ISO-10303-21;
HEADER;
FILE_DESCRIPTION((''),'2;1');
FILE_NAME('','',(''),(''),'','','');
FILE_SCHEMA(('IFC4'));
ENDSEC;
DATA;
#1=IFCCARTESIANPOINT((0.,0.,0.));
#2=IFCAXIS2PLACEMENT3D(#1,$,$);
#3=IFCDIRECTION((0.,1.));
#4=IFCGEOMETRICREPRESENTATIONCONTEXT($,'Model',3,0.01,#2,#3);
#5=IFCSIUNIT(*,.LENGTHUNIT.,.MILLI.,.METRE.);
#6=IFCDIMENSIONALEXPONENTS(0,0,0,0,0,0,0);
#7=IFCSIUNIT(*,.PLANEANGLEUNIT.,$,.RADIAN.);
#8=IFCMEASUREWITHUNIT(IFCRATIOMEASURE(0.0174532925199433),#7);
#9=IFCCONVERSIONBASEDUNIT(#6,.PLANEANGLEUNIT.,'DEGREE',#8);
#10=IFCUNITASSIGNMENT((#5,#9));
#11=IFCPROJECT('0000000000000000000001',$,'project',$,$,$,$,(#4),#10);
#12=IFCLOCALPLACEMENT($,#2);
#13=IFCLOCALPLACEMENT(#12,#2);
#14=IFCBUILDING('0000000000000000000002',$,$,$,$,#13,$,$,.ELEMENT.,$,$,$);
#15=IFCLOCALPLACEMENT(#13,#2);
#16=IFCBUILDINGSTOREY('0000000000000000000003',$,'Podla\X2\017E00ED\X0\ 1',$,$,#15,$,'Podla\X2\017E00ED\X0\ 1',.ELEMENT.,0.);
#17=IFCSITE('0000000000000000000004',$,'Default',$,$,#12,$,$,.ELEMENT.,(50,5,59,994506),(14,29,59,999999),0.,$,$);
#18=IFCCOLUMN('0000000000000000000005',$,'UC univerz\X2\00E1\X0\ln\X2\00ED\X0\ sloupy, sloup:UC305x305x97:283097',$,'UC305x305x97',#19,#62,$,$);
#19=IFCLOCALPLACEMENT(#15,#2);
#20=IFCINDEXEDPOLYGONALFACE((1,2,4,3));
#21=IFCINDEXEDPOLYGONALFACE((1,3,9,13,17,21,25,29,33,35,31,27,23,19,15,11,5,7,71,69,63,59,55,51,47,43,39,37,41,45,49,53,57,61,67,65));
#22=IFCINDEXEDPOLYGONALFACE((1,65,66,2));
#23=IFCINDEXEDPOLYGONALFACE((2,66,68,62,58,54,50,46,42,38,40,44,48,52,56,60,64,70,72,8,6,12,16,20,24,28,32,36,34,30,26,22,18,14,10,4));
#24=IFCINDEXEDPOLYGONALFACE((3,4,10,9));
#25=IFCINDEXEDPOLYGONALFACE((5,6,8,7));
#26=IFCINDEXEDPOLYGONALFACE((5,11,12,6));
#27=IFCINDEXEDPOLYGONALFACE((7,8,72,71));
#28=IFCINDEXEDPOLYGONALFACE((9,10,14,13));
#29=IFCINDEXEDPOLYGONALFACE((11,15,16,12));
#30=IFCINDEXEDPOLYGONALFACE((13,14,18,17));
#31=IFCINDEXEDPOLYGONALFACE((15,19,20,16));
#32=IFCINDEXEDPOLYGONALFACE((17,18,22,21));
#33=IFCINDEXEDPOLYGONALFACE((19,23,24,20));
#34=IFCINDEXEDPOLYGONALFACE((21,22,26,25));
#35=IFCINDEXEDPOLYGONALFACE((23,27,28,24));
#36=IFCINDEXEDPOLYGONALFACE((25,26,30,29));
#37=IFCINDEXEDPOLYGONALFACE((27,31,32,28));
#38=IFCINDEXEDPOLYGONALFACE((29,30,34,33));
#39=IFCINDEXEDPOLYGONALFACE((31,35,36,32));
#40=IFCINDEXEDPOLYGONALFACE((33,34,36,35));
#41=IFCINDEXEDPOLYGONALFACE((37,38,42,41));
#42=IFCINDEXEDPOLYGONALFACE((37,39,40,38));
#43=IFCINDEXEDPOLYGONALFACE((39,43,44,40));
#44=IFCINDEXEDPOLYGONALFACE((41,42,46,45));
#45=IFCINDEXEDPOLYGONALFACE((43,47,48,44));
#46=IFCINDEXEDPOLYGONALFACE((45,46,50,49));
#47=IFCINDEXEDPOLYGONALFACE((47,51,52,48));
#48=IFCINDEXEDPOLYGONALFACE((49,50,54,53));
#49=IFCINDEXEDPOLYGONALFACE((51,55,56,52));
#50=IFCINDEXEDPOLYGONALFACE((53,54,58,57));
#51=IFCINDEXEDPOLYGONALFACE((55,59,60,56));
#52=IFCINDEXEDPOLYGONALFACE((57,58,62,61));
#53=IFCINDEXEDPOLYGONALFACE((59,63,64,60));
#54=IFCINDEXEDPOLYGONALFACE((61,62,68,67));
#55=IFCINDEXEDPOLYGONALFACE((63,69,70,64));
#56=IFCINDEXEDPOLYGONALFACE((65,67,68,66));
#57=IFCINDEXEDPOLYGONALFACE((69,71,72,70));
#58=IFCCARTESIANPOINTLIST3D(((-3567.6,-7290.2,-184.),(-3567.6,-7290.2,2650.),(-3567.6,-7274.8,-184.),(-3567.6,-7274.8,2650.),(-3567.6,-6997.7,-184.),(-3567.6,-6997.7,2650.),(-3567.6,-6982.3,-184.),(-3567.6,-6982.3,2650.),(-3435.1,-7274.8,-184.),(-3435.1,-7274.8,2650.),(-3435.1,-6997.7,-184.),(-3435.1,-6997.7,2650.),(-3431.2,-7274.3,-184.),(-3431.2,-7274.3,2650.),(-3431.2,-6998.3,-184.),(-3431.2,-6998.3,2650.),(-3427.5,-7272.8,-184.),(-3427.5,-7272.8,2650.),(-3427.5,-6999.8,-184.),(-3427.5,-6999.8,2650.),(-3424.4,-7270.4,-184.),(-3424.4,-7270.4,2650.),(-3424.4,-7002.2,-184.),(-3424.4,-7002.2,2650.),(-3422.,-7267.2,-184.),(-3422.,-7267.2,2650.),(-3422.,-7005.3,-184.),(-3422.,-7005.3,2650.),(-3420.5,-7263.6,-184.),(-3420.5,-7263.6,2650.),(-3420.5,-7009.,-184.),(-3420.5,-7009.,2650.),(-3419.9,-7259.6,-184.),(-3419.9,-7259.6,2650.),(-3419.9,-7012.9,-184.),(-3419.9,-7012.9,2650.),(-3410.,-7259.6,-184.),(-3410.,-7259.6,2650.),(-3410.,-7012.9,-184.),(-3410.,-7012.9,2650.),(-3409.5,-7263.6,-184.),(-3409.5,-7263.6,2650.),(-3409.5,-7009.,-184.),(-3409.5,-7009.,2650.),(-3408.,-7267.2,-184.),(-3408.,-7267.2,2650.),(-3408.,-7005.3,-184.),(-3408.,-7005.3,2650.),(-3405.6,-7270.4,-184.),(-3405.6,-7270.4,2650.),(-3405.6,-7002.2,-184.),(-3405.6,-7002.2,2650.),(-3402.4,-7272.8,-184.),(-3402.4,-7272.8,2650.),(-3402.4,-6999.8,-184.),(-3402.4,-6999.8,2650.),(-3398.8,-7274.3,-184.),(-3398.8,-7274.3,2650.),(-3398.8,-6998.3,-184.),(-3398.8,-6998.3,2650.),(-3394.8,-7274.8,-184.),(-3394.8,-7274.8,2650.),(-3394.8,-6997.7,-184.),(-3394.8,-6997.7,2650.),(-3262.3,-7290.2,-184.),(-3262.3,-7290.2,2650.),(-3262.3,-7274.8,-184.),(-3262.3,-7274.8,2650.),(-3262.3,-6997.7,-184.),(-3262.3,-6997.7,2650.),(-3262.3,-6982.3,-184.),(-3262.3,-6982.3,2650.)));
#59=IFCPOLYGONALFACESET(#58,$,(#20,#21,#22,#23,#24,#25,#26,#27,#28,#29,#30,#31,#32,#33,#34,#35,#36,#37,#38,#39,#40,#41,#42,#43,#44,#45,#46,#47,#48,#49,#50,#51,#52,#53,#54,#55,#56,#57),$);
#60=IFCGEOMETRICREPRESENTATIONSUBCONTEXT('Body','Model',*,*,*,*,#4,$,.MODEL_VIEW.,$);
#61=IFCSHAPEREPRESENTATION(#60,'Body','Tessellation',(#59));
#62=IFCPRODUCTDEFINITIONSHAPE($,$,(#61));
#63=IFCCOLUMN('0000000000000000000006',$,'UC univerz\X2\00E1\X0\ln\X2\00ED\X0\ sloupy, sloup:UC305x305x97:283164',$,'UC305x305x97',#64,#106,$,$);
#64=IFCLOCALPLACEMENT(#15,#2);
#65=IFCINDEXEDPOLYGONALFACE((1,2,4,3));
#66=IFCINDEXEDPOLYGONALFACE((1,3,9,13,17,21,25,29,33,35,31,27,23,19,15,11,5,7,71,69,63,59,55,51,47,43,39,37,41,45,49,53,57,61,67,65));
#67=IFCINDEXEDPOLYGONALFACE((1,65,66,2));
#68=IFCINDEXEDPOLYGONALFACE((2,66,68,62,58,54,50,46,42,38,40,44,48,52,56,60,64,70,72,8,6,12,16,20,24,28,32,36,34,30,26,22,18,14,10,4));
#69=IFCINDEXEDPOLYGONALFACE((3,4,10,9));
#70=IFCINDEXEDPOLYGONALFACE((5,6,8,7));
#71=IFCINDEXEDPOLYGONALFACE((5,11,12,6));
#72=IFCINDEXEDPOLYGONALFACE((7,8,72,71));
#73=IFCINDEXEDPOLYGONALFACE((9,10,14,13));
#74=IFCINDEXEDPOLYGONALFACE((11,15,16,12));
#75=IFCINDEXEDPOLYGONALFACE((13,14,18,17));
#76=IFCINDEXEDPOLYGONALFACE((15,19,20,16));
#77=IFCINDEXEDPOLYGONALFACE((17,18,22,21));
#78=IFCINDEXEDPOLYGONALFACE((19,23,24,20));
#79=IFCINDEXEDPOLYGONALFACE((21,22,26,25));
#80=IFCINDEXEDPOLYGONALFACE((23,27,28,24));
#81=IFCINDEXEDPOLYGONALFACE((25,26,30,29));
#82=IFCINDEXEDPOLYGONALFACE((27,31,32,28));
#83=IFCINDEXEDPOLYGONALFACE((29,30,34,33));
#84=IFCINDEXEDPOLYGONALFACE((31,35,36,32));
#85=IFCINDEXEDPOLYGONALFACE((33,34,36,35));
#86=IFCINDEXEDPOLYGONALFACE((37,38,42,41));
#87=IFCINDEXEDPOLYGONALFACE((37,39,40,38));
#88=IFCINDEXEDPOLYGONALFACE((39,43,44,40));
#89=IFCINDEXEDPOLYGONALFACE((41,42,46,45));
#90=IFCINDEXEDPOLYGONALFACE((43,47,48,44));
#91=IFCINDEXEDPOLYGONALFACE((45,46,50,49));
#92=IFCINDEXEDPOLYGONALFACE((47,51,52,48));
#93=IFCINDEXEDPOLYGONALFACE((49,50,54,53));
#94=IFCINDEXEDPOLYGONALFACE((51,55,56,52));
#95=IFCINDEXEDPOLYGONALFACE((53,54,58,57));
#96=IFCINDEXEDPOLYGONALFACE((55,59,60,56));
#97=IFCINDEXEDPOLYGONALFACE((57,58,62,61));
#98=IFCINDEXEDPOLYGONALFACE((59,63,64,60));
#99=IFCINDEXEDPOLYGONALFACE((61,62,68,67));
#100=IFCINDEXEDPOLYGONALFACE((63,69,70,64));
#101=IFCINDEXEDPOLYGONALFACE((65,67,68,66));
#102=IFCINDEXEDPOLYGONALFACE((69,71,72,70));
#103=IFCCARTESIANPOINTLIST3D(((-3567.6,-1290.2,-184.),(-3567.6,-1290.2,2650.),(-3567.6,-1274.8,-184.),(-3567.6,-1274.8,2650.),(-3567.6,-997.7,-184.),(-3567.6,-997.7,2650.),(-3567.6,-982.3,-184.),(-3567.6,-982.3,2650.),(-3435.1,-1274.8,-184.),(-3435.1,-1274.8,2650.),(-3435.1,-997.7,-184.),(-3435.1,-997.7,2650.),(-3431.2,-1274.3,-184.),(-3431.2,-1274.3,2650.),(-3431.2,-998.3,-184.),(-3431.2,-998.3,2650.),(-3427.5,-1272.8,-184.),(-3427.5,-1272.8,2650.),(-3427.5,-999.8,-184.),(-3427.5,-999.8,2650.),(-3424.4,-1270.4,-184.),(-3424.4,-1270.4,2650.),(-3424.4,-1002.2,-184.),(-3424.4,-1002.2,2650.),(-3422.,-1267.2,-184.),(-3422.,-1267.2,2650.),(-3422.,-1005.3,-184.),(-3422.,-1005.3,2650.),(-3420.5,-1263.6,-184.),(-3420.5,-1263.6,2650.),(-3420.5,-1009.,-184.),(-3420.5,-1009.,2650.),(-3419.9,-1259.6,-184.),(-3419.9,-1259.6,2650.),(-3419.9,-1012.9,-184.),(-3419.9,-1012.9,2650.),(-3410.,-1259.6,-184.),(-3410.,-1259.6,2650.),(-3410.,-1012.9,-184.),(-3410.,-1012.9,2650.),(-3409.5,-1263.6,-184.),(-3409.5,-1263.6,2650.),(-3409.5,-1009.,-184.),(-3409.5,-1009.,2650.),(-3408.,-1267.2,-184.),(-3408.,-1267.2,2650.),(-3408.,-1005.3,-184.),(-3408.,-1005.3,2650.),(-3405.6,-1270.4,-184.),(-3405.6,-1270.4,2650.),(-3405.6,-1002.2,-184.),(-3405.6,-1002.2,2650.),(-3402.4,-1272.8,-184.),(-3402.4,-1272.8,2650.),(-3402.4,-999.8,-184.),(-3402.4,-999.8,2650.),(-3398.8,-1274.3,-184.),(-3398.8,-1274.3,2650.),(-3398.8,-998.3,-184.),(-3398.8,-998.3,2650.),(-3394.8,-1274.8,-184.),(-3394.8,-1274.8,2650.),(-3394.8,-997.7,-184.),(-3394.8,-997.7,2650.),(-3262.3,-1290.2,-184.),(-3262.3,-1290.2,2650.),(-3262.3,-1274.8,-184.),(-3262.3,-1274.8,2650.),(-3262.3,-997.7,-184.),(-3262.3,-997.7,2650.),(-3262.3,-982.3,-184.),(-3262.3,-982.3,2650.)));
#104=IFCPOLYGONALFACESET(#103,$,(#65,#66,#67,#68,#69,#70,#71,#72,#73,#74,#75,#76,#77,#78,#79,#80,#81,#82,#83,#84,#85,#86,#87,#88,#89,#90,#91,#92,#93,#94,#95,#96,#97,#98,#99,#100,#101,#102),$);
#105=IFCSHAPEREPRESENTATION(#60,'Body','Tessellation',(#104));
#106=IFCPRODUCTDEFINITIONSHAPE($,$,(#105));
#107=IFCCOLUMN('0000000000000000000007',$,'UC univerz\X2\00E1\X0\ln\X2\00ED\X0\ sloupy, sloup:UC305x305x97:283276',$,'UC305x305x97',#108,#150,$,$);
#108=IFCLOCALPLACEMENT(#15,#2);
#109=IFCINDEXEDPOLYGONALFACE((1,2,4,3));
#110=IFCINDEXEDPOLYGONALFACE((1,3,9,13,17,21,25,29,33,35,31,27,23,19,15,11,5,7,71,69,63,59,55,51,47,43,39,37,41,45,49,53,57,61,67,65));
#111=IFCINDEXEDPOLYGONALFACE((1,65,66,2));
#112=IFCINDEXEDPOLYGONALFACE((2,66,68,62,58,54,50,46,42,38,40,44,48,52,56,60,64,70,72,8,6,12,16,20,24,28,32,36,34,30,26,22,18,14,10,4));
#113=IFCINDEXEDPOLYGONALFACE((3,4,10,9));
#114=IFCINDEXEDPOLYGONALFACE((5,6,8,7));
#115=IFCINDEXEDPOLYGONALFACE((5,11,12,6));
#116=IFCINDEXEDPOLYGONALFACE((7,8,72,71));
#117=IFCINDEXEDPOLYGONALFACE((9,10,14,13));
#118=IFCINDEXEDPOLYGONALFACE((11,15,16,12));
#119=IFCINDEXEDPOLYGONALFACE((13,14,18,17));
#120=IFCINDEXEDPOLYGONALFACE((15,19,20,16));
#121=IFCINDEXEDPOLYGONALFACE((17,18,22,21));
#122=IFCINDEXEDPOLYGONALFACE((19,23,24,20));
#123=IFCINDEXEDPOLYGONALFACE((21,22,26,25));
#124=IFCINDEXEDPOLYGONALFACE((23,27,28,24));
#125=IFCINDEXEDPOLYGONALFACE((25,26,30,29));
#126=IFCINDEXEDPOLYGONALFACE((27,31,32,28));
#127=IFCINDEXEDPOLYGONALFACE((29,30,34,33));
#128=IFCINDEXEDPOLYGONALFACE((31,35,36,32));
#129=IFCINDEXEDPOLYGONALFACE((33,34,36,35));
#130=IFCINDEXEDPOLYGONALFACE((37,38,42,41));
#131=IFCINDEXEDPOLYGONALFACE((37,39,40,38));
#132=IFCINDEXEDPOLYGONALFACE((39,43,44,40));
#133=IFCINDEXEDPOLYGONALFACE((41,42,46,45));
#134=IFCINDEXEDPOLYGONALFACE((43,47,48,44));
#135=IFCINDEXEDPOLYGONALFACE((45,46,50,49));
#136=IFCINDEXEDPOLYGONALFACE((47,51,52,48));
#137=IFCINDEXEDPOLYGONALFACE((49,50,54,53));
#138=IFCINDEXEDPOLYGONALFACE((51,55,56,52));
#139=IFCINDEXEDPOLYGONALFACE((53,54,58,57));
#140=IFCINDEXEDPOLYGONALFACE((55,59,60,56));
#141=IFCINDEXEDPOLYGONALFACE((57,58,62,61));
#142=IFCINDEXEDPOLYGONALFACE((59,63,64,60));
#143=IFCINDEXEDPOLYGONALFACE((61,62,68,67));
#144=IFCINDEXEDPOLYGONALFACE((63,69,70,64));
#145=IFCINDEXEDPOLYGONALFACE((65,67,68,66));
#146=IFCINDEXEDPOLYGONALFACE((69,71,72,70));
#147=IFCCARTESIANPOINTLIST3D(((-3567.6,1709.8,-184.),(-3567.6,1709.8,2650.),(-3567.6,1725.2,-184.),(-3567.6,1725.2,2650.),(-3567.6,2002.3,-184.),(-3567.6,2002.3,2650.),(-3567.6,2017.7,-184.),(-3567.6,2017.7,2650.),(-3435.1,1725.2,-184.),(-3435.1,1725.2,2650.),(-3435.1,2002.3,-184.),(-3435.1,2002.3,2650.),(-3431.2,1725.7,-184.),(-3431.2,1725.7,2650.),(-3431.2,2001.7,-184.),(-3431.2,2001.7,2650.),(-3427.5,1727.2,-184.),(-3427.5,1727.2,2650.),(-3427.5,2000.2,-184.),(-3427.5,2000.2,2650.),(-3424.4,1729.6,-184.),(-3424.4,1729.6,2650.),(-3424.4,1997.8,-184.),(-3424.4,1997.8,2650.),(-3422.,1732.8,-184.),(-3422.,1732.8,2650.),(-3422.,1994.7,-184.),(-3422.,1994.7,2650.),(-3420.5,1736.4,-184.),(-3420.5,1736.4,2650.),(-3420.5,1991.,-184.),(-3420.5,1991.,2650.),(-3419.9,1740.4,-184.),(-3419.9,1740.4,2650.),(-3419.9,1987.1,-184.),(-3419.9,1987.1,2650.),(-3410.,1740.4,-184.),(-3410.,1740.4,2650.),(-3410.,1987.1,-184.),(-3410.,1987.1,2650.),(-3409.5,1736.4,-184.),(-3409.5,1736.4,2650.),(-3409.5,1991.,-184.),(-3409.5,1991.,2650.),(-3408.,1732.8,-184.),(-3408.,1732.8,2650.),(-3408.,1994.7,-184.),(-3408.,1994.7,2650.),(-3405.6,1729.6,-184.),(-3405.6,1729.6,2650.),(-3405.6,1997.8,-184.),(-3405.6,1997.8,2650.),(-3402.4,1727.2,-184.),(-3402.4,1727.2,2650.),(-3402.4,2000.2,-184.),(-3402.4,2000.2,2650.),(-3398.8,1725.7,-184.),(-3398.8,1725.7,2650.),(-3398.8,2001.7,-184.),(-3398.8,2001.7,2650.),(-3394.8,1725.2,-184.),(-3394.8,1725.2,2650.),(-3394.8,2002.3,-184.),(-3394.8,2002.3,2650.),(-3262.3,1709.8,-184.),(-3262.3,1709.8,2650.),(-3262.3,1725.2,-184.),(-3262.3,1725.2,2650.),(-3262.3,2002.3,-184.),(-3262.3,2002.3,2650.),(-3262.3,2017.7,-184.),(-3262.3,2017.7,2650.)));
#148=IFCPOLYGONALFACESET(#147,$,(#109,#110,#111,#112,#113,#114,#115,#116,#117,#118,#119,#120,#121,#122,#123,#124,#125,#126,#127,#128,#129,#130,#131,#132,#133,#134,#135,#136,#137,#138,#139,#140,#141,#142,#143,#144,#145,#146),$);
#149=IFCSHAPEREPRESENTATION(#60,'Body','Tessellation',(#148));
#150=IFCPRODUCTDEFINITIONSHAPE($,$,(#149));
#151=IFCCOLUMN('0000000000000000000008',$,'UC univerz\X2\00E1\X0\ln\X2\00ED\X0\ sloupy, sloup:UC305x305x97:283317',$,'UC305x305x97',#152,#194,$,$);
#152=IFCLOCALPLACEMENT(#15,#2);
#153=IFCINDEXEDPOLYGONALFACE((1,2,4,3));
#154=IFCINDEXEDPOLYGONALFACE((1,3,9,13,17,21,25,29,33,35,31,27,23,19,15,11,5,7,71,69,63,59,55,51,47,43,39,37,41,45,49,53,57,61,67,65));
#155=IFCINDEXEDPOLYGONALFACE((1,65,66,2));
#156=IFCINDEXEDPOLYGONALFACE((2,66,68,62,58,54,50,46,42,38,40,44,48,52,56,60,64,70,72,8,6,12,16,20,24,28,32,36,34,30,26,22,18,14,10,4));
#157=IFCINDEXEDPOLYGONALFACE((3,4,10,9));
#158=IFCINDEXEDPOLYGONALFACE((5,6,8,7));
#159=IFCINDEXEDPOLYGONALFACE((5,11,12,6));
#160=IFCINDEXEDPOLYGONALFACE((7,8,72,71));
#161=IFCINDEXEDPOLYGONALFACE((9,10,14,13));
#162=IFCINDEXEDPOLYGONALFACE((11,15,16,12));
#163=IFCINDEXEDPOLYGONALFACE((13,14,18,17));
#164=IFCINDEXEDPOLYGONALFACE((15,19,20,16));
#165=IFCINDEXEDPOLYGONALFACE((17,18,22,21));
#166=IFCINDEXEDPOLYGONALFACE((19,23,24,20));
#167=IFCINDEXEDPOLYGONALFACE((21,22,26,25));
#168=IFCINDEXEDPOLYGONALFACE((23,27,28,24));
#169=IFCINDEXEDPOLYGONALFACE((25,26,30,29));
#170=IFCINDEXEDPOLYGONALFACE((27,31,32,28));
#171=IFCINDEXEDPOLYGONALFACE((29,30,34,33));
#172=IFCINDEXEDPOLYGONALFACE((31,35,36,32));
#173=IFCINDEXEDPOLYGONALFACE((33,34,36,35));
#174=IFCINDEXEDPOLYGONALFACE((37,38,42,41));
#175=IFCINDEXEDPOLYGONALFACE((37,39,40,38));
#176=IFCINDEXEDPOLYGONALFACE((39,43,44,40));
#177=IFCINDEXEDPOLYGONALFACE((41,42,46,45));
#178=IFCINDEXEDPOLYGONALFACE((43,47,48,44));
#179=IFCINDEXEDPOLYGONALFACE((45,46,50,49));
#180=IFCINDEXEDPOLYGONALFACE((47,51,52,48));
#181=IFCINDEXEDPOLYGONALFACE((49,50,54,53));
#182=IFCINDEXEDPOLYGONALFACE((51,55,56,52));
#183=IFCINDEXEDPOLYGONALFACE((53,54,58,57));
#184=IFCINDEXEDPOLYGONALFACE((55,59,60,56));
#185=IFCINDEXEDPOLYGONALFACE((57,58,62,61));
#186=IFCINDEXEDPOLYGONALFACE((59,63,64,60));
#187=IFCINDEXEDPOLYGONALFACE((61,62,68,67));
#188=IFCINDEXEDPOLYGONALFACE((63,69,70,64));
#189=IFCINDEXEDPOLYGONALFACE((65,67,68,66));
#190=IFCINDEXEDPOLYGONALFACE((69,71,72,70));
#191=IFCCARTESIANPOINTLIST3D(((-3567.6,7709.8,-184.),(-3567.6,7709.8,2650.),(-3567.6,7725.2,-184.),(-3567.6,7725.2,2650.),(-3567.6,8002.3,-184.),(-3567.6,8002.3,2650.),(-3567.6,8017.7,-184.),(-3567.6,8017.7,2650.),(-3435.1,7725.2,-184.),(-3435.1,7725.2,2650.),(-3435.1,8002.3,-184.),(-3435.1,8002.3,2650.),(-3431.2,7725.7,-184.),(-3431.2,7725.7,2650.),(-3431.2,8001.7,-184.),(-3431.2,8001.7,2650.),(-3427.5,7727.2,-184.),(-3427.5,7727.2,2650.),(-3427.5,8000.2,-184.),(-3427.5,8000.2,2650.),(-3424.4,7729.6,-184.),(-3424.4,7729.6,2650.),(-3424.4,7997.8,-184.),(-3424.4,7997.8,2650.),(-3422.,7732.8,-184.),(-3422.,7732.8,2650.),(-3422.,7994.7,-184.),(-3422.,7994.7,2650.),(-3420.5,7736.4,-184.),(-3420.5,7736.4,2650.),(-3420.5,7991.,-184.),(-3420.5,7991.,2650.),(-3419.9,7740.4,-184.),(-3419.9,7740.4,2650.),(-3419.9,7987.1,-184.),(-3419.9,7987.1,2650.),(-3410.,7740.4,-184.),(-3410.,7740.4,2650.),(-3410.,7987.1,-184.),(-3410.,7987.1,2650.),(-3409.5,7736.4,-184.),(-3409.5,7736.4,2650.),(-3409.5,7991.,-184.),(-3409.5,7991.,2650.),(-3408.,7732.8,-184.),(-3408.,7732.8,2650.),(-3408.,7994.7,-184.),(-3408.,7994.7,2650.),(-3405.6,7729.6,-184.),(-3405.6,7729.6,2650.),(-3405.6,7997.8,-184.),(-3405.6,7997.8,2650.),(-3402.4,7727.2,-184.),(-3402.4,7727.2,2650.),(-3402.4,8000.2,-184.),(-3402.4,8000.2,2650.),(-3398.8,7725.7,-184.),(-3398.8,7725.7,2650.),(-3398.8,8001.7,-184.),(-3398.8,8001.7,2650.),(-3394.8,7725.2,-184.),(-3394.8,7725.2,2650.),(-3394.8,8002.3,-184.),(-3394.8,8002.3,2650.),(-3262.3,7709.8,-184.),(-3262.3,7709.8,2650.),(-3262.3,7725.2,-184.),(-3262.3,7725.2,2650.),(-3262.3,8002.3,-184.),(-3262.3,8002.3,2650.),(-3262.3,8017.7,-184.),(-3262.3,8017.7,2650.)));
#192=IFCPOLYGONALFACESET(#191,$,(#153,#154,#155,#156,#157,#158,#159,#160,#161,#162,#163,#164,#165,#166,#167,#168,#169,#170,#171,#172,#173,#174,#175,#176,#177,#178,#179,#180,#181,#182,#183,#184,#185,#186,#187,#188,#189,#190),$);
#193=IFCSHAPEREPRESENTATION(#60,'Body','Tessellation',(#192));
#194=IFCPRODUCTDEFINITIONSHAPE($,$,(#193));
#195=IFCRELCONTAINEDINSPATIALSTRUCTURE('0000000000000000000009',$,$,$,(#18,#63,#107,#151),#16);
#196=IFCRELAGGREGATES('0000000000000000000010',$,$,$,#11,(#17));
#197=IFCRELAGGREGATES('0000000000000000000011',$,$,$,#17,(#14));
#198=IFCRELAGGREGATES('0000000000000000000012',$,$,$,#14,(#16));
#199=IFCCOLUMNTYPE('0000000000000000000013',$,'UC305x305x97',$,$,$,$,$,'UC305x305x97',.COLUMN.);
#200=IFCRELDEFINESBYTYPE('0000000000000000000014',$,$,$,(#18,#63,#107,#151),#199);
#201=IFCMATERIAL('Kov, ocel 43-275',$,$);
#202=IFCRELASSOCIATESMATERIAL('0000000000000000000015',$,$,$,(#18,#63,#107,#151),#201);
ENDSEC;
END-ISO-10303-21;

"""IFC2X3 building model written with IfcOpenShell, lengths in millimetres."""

from ifc_helpers import new_model, entity, si_unit, converted_unit, direction, frame, origin, origin_2d_with_axis, place, context, subcontext, project, spatial, i_section, extrude, source, transform, mapped, material, type_object, type_shapes, element, save


model = new_model("IFC2X3")

# Units and contexts
model_context = context("Model", 3, precision=0.01, world=origin(), true_north=direction((0.0, 1.0)))
body_context = subcontext(model_context, "Body", "Model", "MODEL_VIEW")
ifc_project = project(units=[si_unit("LENGTHUNIT", "METRE", prefix="MILLI"), converted_unit("PLANEANGLEUNIT", "DEGREE", entity("IfcRatioMeasure", 0.0174532925199433), si_unit("PLANEANGLEUNIT", "RADIAN"), dimensions=[0, 0, 0, 0, 0, 0, 0])], contexts=[model_context])

# Site, building, storey
site_placement = place(None, origin())
site = spatial("IfcSite", under=ifc_project, at=site_placement, Name="Default", CompositionType="ELEMENT", RefLatitude=(50, 5, 59, 994506), RefLongitude=(14, 29, 59, 999999), RefElevation=0.0)
building_placement = place(site_placement, origin())
building = spatial("IfcBuilding", under=site, at=building_placement, CompositionType="ELEMENT")
storey_placement = place(building_placement, origin())
storey = spatial("IfcBuildingStorey", under=building, at=storey_placement, Name="Podlaží 1", LongName="Podlaží 1", CompositionType="ELEMENT", Elevation=0.0)

# Columns
ifc_material_1 = material(Name="Kov, ocel 43-275")
column_type = type_object("IfcColumnType", Name="UC305x305x97", ElementType="UC305x305x97", PredefinedType="COLUMN")
shared_shape_1 = source(origin(), body_context, "Body", "SweptSolid", [
    extrude(i_section(OverallWidth=305.3, OverallDepth=307.9, WebThickness=9.9, FlangeThickness=15.4, FilletRadius=15.2, at=origin_2d_with_axis()), frame((0.0, 0.0, -184.0), z_axis=(0.0, 0.0, 1.0), x_axis=(-1.0, 0.0, 0.0)), (0.0, 0.0, 1.0), 2834.0),
])
type_shapes(column_type, [shared_shape_1])
for number, where, name in (
    (1, (-3415.0, -7136.3, 0.0), "UC univerzální sloupy, sloup:UC305x305x97:283097"),
    (2, (-3415.0, -1136.3, 0.0), "UC univerzální sloupy, sloup:UC305x305x97:283164"),
    (3, (-3415.0, 1863.7, 0.0), "UC univerzální sloupy, sloup:UC305x305x97:283276"),
    (4, (-3415.0, 7863.7, 0.0), "UC univerzální sloupy, sloup:UC305x305x97:283317"),
):
    element("IfcColumn", number, at=place(storey_placement, frame(where)), inside=storey, type_object=column_type, material=ifc_material_1, Name=name, ObjectType="UC305x305x97", context=body_context, shape_type="MappedRepresentation", body=[
        mapped(shared_shape_1, transform((0.0, 0.0, 0.0), scale=1.0)),
    ])

save(model, "model.ifc")
